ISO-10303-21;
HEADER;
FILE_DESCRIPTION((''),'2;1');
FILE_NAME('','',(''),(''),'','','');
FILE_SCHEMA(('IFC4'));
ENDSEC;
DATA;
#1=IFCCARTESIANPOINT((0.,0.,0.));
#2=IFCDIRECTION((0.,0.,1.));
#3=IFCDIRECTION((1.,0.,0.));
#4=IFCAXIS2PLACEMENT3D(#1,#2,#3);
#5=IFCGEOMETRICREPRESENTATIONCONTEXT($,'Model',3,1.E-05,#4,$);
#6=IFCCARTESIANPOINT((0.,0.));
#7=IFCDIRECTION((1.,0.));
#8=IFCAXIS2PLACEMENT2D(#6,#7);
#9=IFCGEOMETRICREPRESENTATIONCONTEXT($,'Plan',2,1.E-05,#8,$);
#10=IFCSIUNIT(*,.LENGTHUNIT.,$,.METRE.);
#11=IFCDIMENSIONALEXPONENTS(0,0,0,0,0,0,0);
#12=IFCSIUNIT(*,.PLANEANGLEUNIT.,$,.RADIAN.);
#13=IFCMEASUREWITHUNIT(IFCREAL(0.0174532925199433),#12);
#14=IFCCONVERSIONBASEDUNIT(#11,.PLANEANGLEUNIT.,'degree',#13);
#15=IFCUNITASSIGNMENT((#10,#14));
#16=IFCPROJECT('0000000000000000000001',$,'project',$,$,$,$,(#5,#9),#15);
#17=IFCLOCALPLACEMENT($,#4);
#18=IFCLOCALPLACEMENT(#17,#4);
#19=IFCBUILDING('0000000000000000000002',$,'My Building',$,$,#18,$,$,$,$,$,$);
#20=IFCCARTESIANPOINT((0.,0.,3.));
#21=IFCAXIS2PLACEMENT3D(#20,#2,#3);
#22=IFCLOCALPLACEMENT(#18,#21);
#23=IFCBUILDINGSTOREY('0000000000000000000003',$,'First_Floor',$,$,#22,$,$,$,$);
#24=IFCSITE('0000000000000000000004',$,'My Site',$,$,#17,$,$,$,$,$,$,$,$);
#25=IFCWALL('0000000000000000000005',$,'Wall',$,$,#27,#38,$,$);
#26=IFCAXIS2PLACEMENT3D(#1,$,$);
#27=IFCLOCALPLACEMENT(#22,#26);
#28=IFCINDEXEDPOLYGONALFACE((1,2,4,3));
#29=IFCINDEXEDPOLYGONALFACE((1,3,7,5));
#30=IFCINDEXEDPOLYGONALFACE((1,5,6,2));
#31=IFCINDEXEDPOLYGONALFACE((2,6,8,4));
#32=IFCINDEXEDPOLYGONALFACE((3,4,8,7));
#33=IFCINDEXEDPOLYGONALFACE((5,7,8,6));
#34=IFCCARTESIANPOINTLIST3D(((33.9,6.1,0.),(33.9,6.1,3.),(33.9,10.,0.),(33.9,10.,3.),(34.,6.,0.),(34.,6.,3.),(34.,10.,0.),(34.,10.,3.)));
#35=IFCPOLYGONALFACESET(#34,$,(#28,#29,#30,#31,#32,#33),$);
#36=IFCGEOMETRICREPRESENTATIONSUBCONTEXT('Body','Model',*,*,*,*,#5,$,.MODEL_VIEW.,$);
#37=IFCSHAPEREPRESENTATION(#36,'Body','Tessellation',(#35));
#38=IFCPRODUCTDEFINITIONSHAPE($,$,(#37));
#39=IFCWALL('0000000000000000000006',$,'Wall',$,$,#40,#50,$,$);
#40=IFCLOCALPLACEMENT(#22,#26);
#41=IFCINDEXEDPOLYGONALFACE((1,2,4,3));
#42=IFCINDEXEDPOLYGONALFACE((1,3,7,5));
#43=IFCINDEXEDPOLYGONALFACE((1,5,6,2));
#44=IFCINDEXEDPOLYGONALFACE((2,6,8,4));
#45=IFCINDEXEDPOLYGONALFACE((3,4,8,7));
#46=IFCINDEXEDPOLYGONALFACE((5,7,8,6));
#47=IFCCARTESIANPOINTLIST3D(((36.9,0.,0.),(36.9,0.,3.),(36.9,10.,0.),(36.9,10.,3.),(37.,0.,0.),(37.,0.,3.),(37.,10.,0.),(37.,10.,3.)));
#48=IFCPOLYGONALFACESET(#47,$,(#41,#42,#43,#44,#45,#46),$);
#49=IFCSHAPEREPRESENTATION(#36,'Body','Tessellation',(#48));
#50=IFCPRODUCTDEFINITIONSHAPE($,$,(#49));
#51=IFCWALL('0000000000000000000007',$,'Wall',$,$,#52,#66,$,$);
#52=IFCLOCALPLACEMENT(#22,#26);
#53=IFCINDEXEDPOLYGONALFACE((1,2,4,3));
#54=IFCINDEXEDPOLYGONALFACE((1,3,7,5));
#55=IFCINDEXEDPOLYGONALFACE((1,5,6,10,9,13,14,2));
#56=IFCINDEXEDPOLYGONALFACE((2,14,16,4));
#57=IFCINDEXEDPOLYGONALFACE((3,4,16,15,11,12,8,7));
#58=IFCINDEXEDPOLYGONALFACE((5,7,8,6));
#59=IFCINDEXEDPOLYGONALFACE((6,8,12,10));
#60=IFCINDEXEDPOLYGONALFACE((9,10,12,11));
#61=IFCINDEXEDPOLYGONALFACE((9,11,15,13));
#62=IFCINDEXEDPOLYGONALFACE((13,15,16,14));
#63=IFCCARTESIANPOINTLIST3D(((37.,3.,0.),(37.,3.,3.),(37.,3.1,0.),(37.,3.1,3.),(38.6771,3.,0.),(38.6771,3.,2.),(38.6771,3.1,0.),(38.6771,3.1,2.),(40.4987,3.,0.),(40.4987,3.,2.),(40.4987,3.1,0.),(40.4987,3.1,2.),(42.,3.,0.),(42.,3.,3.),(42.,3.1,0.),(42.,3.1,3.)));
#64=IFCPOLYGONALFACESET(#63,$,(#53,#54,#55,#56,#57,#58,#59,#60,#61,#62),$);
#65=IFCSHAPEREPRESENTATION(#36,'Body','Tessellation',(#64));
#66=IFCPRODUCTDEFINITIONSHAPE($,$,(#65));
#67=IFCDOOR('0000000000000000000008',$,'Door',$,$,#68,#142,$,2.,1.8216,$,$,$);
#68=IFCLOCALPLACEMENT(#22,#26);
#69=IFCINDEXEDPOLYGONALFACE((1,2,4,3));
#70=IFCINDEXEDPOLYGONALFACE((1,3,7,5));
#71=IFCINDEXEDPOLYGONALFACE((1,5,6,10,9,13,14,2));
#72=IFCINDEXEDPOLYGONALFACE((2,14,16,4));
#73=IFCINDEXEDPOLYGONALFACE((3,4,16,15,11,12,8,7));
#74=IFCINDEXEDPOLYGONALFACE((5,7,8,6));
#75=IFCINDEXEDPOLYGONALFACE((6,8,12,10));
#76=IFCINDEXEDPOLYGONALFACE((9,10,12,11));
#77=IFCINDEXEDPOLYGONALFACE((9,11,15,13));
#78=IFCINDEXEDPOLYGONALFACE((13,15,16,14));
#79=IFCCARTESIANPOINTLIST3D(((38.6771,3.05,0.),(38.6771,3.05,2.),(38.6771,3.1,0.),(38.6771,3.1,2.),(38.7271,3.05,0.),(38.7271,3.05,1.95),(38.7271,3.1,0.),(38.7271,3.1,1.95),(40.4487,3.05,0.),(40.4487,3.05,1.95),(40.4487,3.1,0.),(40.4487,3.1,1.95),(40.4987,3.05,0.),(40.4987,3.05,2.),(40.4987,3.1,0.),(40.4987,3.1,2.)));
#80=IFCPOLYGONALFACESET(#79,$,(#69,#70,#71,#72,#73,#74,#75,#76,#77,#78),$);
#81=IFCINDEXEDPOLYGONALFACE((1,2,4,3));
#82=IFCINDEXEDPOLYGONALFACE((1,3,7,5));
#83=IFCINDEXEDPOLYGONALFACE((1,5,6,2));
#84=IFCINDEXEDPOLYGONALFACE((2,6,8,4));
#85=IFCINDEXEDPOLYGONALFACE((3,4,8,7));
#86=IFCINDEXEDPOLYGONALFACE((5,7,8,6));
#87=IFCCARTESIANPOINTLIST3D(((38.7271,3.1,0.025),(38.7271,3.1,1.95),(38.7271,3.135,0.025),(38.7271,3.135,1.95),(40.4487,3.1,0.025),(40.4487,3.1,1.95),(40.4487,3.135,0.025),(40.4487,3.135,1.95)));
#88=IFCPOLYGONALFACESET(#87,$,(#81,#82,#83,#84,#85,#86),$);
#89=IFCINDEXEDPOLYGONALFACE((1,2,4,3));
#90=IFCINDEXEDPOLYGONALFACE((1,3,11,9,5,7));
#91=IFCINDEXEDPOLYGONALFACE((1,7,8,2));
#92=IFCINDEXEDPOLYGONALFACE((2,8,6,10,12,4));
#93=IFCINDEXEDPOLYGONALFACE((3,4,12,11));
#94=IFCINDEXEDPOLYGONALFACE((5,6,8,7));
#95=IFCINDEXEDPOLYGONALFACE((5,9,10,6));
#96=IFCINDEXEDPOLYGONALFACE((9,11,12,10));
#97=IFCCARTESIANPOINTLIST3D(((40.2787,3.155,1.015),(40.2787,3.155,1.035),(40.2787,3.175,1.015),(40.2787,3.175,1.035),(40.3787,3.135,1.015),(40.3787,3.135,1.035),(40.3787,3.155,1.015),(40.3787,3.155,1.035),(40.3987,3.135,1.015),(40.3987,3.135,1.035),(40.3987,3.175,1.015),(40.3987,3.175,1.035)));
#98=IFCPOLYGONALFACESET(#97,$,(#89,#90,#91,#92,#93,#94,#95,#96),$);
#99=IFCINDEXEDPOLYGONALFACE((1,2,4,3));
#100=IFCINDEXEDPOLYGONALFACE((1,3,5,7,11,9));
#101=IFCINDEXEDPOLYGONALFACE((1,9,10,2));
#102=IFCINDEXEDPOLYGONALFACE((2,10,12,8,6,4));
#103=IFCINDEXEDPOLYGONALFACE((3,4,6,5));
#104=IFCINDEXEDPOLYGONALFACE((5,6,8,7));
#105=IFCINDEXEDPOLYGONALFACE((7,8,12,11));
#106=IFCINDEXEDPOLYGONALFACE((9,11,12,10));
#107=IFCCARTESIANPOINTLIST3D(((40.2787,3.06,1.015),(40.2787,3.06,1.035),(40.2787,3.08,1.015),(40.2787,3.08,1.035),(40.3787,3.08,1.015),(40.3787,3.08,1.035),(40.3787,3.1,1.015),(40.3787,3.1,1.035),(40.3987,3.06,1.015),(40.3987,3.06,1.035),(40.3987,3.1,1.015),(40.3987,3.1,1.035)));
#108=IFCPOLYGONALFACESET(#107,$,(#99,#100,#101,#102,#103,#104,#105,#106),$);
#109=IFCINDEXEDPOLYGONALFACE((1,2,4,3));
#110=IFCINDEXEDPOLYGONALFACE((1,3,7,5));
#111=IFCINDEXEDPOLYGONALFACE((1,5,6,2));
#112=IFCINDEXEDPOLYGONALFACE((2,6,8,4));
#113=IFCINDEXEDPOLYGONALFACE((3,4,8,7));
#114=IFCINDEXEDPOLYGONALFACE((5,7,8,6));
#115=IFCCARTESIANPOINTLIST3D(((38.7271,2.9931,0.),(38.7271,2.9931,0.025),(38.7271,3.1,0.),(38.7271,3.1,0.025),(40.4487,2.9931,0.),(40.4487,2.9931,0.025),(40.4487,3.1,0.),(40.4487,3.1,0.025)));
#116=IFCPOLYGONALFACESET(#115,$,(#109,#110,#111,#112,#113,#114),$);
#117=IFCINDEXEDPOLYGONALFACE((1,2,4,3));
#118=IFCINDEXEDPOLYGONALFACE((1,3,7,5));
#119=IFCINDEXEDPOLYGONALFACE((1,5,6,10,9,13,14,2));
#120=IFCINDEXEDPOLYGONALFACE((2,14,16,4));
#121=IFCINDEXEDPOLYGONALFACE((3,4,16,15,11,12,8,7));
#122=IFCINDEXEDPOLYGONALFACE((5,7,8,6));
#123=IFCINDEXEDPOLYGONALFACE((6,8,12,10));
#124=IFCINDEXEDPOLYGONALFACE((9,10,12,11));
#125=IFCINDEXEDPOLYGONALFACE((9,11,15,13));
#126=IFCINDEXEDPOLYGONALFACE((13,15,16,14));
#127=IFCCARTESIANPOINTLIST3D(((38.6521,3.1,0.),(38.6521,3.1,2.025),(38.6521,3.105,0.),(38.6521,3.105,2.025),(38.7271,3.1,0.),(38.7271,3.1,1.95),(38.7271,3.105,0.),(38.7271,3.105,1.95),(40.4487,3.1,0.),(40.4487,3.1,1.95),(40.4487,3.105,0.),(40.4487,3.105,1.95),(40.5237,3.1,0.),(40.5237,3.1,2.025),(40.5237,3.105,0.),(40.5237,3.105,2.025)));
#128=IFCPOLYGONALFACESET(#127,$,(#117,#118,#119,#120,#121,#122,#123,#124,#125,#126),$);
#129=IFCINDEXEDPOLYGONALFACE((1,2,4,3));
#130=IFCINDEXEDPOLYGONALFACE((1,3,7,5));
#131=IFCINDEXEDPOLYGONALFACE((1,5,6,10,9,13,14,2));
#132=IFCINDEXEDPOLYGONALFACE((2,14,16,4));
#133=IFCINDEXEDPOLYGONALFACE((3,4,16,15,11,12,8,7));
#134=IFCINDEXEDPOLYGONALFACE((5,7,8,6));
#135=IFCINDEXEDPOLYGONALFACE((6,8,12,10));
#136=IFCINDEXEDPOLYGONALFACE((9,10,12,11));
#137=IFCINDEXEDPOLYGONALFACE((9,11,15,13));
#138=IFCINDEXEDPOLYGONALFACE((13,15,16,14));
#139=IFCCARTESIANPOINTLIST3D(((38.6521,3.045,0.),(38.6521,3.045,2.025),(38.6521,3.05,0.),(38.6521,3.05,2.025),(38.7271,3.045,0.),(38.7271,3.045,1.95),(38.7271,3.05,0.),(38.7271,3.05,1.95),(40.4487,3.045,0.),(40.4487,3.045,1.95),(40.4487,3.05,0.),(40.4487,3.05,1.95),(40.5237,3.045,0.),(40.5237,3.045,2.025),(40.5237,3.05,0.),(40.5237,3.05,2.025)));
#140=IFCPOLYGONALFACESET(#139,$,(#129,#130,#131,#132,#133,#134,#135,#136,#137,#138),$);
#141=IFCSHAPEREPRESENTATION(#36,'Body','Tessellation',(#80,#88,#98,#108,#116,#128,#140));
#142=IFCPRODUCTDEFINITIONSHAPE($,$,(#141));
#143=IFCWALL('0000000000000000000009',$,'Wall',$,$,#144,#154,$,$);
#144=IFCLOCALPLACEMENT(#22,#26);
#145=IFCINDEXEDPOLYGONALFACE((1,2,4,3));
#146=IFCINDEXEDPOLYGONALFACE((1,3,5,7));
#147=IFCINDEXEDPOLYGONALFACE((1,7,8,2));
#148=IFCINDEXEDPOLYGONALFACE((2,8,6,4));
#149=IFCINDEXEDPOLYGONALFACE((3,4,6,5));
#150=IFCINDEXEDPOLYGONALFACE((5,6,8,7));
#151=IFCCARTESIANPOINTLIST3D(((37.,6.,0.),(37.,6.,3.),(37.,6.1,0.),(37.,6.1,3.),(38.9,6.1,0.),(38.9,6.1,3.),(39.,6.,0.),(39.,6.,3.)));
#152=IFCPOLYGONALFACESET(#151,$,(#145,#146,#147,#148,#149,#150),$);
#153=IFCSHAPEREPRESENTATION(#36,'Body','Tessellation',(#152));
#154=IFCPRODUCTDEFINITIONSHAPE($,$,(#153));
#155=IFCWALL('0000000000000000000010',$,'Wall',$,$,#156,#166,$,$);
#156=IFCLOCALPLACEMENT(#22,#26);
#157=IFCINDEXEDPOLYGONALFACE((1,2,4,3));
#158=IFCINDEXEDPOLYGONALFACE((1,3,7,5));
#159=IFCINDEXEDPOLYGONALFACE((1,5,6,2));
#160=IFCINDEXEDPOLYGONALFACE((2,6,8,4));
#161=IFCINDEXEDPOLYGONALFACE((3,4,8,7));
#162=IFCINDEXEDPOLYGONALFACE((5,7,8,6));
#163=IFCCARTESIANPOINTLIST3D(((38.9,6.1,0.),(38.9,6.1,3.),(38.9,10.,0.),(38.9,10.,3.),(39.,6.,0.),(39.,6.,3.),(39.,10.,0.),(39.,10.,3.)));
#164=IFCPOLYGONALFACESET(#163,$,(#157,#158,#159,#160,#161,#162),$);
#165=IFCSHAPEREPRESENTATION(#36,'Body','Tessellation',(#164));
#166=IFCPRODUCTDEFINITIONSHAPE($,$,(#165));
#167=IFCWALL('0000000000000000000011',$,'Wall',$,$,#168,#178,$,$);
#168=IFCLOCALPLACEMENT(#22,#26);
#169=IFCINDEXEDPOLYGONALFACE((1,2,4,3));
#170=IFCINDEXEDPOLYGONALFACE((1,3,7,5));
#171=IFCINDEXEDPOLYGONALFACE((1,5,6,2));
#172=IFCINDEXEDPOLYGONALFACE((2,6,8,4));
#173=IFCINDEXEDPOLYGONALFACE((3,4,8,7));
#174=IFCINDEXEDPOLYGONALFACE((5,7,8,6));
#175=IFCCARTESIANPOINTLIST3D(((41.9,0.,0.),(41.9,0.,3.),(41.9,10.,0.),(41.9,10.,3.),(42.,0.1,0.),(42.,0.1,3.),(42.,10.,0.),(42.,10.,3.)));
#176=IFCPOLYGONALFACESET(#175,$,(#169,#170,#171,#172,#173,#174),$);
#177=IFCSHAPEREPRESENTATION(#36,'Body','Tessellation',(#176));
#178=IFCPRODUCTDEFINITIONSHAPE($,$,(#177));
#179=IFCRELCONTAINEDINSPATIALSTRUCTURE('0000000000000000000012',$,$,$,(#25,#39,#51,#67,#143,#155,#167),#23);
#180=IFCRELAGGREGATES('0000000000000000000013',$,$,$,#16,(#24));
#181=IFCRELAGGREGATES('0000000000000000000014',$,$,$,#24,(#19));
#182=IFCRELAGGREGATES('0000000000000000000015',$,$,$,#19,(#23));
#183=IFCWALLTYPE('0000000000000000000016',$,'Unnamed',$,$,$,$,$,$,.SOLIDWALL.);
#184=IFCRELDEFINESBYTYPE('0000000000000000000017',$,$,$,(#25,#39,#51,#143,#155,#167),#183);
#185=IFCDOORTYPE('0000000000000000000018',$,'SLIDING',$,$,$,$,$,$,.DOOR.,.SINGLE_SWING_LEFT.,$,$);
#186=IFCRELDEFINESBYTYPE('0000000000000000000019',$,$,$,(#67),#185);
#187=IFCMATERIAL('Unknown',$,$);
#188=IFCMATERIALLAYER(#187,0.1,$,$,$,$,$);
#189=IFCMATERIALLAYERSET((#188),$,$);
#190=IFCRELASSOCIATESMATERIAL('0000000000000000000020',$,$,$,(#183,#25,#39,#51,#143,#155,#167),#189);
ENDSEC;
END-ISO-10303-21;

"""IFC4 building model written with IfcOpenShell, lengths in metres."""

from ifc_helpers import new_model, entity, si_unit, converted_unit, frame, origin_with_axes, origin_2d_with_axis, place, context, subcontext, project, spatial, line, indexed_curve, outline, extrude, shape, source, transform, mapped, material, layer, layer_set, layer_usage, type_object, type_shapes, element, fill, save


model = new_model("IFC4")

# Units and contexts
model_context = context("Model", 3, precision=1e-05, world=origin_with_axes())
plan_context = context("Plan", 2, precision=1e-05, world=origin_2d_with_axis())
body_context_1 = subcontext(model_context, "Body", "Model", "MODEL_VIEW")
body_context_2 = subcontext(plan_context, "Body", "Plan", "PLAN_VIEW")
ifc_project = project(units=[si_unit("LENGTHUNIT", "METRE"), converted_unit("PLANEANGLEUNIT", "degree", entity("IfcReal", 0.0174532925199433), si_unit("PLANEANGLEUNIT", "RADIAN"), dimensions=[0, 0, 0, 0, 0, 0, 0])], contexts=[model_context, plan_context])

# Site, building, storey
site_placement = place(None, origin_with_axes())
site = spatial("IfcSite", under=ifc_project, at=site_placement, Name="My Site")
building_placement = place(site_placement, origin_with_axes())
building = spatial("IfcBuilding", under=site, at=building_placement, Name="My Building")
storey_placement = place(building_placement, frame((0.0, 0.0, 3.0), z_axis=(0.0, 0.0, 1.0), x_axis=(1.0, 0.0, 0.0)))
storey = spatial("IfcBuildingStorey", under=building, at=storey_placement, Name="First_Floor")

# Walls
ifc_material = material(Name="Unknown")
ifc_layer = layer(ifc_material, 0.1)
ifc_layer_set = layer_set([ifc_layer])
ifc_layer_usage_1 = layer_usage(ifc_layer_set, "AXIS2", "POSITIVE", 0.0)
wall_type = type_object("IfcWallType", Name="Unnamed", PredefinedType="SOLIDWALL", material=ifc_layer_set)
wall_1_placement = place(storey_placement, frame((34.0, 6.0, 0.0), z_axis=(0.0, 0.0, 1.0), x_axis=(0.0, 1.0, 0.0)))
element("IfcWall", 1, at=wall_1_placement, inside=storey, type_object=wall_type, material=ifc_layer_usage_1, Name="Wall", context=body_context_1, shape_type="SweptSolid", body=[
    extrude(outline(indexed_curve([(0.0, 0.0), (0.1, 0.1), (4.0, 0.1), (4.0, 0.0)], segments=[line(1, 2, 3, 4, 1)])), origin_with_axes(), (0.0, 0.0, 1.0), 3.0),
])
ifc_layer_usage_2 = layer_usage(ifc_layer_set, "AXIS2", "POSITIVE", 0.0)
wall_2_placement = place(storey_placement, frame((36.9, 10.0, 0.0), z_axis=(0.0, 0.0, 1.0), x_axis=(0.0, -1.0, 0.0)))
element("IfcWall", 2, at=wall_2_placement, inside=storey, type_object=wall_type, material=ifc_layer_usage_2, Name="Wall", context=body_context_1, shape_type="SweptSolid", body=[
    extrude(outline(indexed_curve([(0.0, 0.0), (0.0, 0.1), (10.0, 0.1), (10.0, 0.0)], segments=[line(1, 2, 3, 4, 1)])), origin_with_axes(), (0.0, 0.0, 1.0), 3.0),
])

# Wall, opening, door
ifc_layer_usage_3 = layer_usage(ifc_layer_set, "AXIS2", "POSITIVE", 0.0)
wall_3_placement = place(storey_placement, frame((37.0, 3.0, 0.0), z_axis=(0.0, 0.0, 1.0), x_axis=(1.0, 0.0, 0.0)))
wall_3 = element("IfcWall", 3, at=wall_3_placement, inside=storey, type_object=wall_type, material=ifc_layer_usage_3, Name="Wall", context=body_context_1, shape_type="SweptSolid", body=[
    extrude(outline(indexed_curve([(0.0, 0.0), (0.0, 0.1), (5.0, 0.1), (5.0, 0.0)], segments=[line(1, 2, 3, 4, 1)])), origin_with_axes(), (0.0, 0.0, 1.0), 3.0),
])
shared_shape_1 = source(origin_with_axes(), body_context_1, "Body", "SweptSolid", [
    extrude(outline(indexed_curve([(0.0, 0.0), (1.8216, 0.0), (1.8216, 2.0), (0.0, 2.0)], segments=[line(1, 2, 3, 4, 1)])), frame((0.0, -0.6, 0.0), z_axis=(0.0, -1.0, 0.0), x_axis=(1.0, 0.0, 0.0)), (0.0, 0.0, -1.0), 1.2),
])
opening_placement = place(wall_3_placement, frame((3.4987, 0.1, 0.0), z_axis=(0.0, 0.0, 1.0), x_axis=(-1.0, 0.0, 0.0)))
opening = element("IfcOpeningElement", 4, at=opening_placement, cuts=wall_3, PredefinedType="OPENING", context=body_context_1, shape_type="MappedRepresentation", body=[
    mapped(shared_shape_1, transform((0.0, 0.0, 0.0), x_axis=(1.0, 0.0, 0.0), y_axis=(0.0, 1.0, 0.0), z_axis=(0.0, 0.0, 1.0), scale=1.0)),
])
door_type = type_object("IfcDoorType", Name="SLIDING", OperationType="SINGLE_SWING_LEFT", PredefinedType="DOOR")
shared_shape_2 = source(origin_with_axes(), body_context_1, "Body", "SweptSolid", [
    extrude(outline(indexed_curve([(0.0, 0.0), (0.0, 2.0), (1.8216, 2.0), (1.8216, 0.0), (1.7716, 0.0), (1.7716, 1.95), (0.05, 1.95), (0.05, 0.0)], segments=[line(1, 2, 3, 4, 5, 6, 7, 8, 1)])), frame((0.0, 0.0, 0.0), z_axis=(0.0, -1.0, 0.0), x_axis=(1.0, 0.0, 0.0)), (0.0, 0.0, -1.0), 0.05),
    extrude(outline(indexed_curve([(0.0, 0.0), (1.7216, 0.0), (1.7216, 0.035), (0.0, 0.035)], segments=[line(1, 2, 3, 4, 1)])), frame((0.05, -0.035, 0.025), z_axis=(0.0, 0.0, 1.0), x_axis=(1.0, 0.0, 0.0)), (0.0, 0.0, 1.0), 1.925),
    extrude(outline(indexed_curve([(0.0, 0.0), (0.0, -0.04), (0.12, -0.04), (0.12, -0.02), (0.02, -0.02), (0.02, 0.0)], segments=[line(1, 2, 3, 4, 5, 6, 1)])), frame((0.1, -0.035, 1.015), z_axis=(0.0, 0.0, 1.0), x_axis=(1.0, 0.0, 0.0)), (0.0, 0.0, 1.0), 0.02),
    extrude(outline(indexed_curve([(0.0, 0.0), (0.0, 0.04), (0.12, 0.04), (0.12, 0.02), (0.02, 0.02), (0.02, 0.0)], segments=[line(1, 2, 3, 4, 5, 6, 1)])), frame((0.1, 0.0, 1.015), z_axis=(0.0, 0.0, 1.0), x_axis=(1.0, 0.0, 0.0)), (0.0, 0.0, 1.0), 0.02),
    extrude(outline(indexed_curve([(0.0, 0.0), (1.7216, 0.0), (1.7216, 0.1069), (0.0, 0.1069)], segments=[line(1, 2, 3, 4, 1)])), frame((0.05, 0.0, 0.0), z_axis=(0.0, 0.0, 1.0), x_axis=(1.0, 0.0, 0.0)), (0.0, 0.0, 1.0), 0.025),
    extrude(outline(indexed_curve([(0.0, 0.0), (0.0, 2.025), (1.8716, 2.025), (1.8716, 0.0), (1.7966, 0.0), (1.7966, 1.95), (0.075, 1.95), (0.075, 0.0)], segments=[line(1, 2, 3, 4, 5, 6, 7, 8, 1)])), frame((-0.025, -0.005, 0.0), z_axis=(0.0, -1.0, 0.0), x_axis=(1.0, 0.0, 0.0)), (0.0, 0.0, -1.0), 0.005),
    extrude(outline(indexed_curve([(0.0, 0.0), (0.0, 2.025), (1.8716, 2.025), (1.8716, 0.0), (1.7966, 0.0), (1.7966, 1.95), (0.075, 1.95), (0.075, 0.0)], segments=[line(1, 2, 3, 4, 5, 6, 7, 8, 1)])), frame((-0.025, 0.05, 0.0), z_axis=(0.0, -1.0, 0.0), x_axis=(1.0, 0.0, 0.0)), (0.0, 0.0, -1.0), 0.005),
])
shared_shape_3 = source(origin_with_axes(), body_context_2, "Body", "Curve2D", [
    entity("IfcIndexedPolyCurve", entity("IfcCartesianPointList2D", [[0.0, 0.0], [0.05, 0.0], [0.05, 0.05], [0.0, 0.05]]), [entity("IfcLineIndex", [1, 2, 3, 4, 1])]),
    entity("IfcIndexedPolyCurve", entity("IfcCartesianPointList2D", [[1.8216, 0.0], [1.7716, 0.0], [1.7716, 0.05], [1.8216, 0.05]]), [entity("IfcLineIndex", [1, 2, 3, 4, 1])]),
    entity("IfcIndexedPolyCurve", entity("IfcCartesianPointList2D", [[2.6325, -0.035], [0.9108, -0.035], [0.9108, 0.0], [2.6325, 0.0]]), [entity("IfcLineIndex", [1, 2, 3, 4, 1])]),
])
type_shapes(door_type, [shared_shape_2, shared_shape_3])
door_placement = place(opening_placement, origin_with_axes())
door = element("IfcDoor", 5, at=door_placement, inside=storey, type_object=door_type, Name="Door", OverallHeight=2.0, OverallWidth=1.8216, shapes=[
    shape(body_context_1, "Body", "MappedRepresentation", [mapped(shared_shape_2, transform((0.0, 0.0, 0.0), x_axis=(1.0, 0.0, 0.0), y_axis=(0.0, 1.0, 0.0), z_axis=(0.0, 0.0, 1.0), scale=1.0))]),
    shape(body_context_2, "Body", "MappedRepresentation", [mapped(shared_shape_3, transform((0.0, 0.0, 0.0), x_axis=(1.0, 0.0, 0.0), y_axis=(0.0, 1.0, 0.0), z_axis=(0.0, 0.0, 1.0), scale=1.0))]),
])
fill(opening, door)

# Walls
ifc_layer_usage_4 = layer_usage(ifc_layer_set, "AXIS2", "POSITIVE", 0.0)
wall_4_placement = place(storey_placement, frame((37.0, 6.0, 0.0), z_axis=(0.0, 0.0, 1.0), x_axis=(1.0, 0.0, 0.0)))
element("IfcWall", 6, at=wall_4_placement, inside=storey, type_object=wall_type, material=ifc_layer_usage_4, Name="Wall", context=body_context_1, shape_type="SweptSolid", body=[
    extrude(outline(indexed_curve([(0.0, 0.0), (0.0, 0.1), (1.9, 0.1), (2.0, 0.0)], segments=[line(1, 2, 3, 4, 1)])), origin_with_axes(), (0.0, 0.0, 1.0), 3.0),
])
ifc_layer_usage_5 = layer_usage(ifc_layer_set, "AXIS2", "POSITIVE", 0.0)
wall_5_placement = place(storey_placement, frame((39.0, 6.0, 0.0), z_axis=(0.0, 0.0, 1.0), x_axis=(0.0, 1.0, 0.0)))
element("IfcWall", 7, at=wall_5_placement, inside=storey, type_object=wall_type, material=ifc_layer_usage_5, Name="Wall", context=body_context_1, shape_type="SweptSolid", body=[
    extrude(outline(indexed_curve([(0.0, 0.0), (0.1, 0.1), (4.0, 0.1), (4.0, 0.0)], segments=[line(1, 2, 3, 4, 1)])), origin_with_axes(), (0.0, 0.0, 1.0), 3.0),
])
ifc_layer_usage_6 = layer_usage(ifc_layer_set, "AXIS2", "POSITIVE", 0.0)
wall_6_placement = place(storey_placement, frame((41.9, 10.0, 0.0), z_axis=(0.0, 0.0, 1.0), x_axis=(0.0, -1.0, 0.0)))
element("IfcWall", 8, at=wall_6_placement, inside=storey, type_object=wall_type, material=ifc_layer_usage_6, Name="Wall", context=body_context_1, shape_type="SweptSolid", body=[
    extrude(outline(indexed_curve([(0.0, 0.0), (0.0, 0.1), (9.9, 0.1), (10.0, 0.0)], segments=[line(1, 2, 3, 4, 1)])), origin_with_axes(), (0.0, 0.0, 1.0), 3.0),
])

save(model, "model.ifc")
